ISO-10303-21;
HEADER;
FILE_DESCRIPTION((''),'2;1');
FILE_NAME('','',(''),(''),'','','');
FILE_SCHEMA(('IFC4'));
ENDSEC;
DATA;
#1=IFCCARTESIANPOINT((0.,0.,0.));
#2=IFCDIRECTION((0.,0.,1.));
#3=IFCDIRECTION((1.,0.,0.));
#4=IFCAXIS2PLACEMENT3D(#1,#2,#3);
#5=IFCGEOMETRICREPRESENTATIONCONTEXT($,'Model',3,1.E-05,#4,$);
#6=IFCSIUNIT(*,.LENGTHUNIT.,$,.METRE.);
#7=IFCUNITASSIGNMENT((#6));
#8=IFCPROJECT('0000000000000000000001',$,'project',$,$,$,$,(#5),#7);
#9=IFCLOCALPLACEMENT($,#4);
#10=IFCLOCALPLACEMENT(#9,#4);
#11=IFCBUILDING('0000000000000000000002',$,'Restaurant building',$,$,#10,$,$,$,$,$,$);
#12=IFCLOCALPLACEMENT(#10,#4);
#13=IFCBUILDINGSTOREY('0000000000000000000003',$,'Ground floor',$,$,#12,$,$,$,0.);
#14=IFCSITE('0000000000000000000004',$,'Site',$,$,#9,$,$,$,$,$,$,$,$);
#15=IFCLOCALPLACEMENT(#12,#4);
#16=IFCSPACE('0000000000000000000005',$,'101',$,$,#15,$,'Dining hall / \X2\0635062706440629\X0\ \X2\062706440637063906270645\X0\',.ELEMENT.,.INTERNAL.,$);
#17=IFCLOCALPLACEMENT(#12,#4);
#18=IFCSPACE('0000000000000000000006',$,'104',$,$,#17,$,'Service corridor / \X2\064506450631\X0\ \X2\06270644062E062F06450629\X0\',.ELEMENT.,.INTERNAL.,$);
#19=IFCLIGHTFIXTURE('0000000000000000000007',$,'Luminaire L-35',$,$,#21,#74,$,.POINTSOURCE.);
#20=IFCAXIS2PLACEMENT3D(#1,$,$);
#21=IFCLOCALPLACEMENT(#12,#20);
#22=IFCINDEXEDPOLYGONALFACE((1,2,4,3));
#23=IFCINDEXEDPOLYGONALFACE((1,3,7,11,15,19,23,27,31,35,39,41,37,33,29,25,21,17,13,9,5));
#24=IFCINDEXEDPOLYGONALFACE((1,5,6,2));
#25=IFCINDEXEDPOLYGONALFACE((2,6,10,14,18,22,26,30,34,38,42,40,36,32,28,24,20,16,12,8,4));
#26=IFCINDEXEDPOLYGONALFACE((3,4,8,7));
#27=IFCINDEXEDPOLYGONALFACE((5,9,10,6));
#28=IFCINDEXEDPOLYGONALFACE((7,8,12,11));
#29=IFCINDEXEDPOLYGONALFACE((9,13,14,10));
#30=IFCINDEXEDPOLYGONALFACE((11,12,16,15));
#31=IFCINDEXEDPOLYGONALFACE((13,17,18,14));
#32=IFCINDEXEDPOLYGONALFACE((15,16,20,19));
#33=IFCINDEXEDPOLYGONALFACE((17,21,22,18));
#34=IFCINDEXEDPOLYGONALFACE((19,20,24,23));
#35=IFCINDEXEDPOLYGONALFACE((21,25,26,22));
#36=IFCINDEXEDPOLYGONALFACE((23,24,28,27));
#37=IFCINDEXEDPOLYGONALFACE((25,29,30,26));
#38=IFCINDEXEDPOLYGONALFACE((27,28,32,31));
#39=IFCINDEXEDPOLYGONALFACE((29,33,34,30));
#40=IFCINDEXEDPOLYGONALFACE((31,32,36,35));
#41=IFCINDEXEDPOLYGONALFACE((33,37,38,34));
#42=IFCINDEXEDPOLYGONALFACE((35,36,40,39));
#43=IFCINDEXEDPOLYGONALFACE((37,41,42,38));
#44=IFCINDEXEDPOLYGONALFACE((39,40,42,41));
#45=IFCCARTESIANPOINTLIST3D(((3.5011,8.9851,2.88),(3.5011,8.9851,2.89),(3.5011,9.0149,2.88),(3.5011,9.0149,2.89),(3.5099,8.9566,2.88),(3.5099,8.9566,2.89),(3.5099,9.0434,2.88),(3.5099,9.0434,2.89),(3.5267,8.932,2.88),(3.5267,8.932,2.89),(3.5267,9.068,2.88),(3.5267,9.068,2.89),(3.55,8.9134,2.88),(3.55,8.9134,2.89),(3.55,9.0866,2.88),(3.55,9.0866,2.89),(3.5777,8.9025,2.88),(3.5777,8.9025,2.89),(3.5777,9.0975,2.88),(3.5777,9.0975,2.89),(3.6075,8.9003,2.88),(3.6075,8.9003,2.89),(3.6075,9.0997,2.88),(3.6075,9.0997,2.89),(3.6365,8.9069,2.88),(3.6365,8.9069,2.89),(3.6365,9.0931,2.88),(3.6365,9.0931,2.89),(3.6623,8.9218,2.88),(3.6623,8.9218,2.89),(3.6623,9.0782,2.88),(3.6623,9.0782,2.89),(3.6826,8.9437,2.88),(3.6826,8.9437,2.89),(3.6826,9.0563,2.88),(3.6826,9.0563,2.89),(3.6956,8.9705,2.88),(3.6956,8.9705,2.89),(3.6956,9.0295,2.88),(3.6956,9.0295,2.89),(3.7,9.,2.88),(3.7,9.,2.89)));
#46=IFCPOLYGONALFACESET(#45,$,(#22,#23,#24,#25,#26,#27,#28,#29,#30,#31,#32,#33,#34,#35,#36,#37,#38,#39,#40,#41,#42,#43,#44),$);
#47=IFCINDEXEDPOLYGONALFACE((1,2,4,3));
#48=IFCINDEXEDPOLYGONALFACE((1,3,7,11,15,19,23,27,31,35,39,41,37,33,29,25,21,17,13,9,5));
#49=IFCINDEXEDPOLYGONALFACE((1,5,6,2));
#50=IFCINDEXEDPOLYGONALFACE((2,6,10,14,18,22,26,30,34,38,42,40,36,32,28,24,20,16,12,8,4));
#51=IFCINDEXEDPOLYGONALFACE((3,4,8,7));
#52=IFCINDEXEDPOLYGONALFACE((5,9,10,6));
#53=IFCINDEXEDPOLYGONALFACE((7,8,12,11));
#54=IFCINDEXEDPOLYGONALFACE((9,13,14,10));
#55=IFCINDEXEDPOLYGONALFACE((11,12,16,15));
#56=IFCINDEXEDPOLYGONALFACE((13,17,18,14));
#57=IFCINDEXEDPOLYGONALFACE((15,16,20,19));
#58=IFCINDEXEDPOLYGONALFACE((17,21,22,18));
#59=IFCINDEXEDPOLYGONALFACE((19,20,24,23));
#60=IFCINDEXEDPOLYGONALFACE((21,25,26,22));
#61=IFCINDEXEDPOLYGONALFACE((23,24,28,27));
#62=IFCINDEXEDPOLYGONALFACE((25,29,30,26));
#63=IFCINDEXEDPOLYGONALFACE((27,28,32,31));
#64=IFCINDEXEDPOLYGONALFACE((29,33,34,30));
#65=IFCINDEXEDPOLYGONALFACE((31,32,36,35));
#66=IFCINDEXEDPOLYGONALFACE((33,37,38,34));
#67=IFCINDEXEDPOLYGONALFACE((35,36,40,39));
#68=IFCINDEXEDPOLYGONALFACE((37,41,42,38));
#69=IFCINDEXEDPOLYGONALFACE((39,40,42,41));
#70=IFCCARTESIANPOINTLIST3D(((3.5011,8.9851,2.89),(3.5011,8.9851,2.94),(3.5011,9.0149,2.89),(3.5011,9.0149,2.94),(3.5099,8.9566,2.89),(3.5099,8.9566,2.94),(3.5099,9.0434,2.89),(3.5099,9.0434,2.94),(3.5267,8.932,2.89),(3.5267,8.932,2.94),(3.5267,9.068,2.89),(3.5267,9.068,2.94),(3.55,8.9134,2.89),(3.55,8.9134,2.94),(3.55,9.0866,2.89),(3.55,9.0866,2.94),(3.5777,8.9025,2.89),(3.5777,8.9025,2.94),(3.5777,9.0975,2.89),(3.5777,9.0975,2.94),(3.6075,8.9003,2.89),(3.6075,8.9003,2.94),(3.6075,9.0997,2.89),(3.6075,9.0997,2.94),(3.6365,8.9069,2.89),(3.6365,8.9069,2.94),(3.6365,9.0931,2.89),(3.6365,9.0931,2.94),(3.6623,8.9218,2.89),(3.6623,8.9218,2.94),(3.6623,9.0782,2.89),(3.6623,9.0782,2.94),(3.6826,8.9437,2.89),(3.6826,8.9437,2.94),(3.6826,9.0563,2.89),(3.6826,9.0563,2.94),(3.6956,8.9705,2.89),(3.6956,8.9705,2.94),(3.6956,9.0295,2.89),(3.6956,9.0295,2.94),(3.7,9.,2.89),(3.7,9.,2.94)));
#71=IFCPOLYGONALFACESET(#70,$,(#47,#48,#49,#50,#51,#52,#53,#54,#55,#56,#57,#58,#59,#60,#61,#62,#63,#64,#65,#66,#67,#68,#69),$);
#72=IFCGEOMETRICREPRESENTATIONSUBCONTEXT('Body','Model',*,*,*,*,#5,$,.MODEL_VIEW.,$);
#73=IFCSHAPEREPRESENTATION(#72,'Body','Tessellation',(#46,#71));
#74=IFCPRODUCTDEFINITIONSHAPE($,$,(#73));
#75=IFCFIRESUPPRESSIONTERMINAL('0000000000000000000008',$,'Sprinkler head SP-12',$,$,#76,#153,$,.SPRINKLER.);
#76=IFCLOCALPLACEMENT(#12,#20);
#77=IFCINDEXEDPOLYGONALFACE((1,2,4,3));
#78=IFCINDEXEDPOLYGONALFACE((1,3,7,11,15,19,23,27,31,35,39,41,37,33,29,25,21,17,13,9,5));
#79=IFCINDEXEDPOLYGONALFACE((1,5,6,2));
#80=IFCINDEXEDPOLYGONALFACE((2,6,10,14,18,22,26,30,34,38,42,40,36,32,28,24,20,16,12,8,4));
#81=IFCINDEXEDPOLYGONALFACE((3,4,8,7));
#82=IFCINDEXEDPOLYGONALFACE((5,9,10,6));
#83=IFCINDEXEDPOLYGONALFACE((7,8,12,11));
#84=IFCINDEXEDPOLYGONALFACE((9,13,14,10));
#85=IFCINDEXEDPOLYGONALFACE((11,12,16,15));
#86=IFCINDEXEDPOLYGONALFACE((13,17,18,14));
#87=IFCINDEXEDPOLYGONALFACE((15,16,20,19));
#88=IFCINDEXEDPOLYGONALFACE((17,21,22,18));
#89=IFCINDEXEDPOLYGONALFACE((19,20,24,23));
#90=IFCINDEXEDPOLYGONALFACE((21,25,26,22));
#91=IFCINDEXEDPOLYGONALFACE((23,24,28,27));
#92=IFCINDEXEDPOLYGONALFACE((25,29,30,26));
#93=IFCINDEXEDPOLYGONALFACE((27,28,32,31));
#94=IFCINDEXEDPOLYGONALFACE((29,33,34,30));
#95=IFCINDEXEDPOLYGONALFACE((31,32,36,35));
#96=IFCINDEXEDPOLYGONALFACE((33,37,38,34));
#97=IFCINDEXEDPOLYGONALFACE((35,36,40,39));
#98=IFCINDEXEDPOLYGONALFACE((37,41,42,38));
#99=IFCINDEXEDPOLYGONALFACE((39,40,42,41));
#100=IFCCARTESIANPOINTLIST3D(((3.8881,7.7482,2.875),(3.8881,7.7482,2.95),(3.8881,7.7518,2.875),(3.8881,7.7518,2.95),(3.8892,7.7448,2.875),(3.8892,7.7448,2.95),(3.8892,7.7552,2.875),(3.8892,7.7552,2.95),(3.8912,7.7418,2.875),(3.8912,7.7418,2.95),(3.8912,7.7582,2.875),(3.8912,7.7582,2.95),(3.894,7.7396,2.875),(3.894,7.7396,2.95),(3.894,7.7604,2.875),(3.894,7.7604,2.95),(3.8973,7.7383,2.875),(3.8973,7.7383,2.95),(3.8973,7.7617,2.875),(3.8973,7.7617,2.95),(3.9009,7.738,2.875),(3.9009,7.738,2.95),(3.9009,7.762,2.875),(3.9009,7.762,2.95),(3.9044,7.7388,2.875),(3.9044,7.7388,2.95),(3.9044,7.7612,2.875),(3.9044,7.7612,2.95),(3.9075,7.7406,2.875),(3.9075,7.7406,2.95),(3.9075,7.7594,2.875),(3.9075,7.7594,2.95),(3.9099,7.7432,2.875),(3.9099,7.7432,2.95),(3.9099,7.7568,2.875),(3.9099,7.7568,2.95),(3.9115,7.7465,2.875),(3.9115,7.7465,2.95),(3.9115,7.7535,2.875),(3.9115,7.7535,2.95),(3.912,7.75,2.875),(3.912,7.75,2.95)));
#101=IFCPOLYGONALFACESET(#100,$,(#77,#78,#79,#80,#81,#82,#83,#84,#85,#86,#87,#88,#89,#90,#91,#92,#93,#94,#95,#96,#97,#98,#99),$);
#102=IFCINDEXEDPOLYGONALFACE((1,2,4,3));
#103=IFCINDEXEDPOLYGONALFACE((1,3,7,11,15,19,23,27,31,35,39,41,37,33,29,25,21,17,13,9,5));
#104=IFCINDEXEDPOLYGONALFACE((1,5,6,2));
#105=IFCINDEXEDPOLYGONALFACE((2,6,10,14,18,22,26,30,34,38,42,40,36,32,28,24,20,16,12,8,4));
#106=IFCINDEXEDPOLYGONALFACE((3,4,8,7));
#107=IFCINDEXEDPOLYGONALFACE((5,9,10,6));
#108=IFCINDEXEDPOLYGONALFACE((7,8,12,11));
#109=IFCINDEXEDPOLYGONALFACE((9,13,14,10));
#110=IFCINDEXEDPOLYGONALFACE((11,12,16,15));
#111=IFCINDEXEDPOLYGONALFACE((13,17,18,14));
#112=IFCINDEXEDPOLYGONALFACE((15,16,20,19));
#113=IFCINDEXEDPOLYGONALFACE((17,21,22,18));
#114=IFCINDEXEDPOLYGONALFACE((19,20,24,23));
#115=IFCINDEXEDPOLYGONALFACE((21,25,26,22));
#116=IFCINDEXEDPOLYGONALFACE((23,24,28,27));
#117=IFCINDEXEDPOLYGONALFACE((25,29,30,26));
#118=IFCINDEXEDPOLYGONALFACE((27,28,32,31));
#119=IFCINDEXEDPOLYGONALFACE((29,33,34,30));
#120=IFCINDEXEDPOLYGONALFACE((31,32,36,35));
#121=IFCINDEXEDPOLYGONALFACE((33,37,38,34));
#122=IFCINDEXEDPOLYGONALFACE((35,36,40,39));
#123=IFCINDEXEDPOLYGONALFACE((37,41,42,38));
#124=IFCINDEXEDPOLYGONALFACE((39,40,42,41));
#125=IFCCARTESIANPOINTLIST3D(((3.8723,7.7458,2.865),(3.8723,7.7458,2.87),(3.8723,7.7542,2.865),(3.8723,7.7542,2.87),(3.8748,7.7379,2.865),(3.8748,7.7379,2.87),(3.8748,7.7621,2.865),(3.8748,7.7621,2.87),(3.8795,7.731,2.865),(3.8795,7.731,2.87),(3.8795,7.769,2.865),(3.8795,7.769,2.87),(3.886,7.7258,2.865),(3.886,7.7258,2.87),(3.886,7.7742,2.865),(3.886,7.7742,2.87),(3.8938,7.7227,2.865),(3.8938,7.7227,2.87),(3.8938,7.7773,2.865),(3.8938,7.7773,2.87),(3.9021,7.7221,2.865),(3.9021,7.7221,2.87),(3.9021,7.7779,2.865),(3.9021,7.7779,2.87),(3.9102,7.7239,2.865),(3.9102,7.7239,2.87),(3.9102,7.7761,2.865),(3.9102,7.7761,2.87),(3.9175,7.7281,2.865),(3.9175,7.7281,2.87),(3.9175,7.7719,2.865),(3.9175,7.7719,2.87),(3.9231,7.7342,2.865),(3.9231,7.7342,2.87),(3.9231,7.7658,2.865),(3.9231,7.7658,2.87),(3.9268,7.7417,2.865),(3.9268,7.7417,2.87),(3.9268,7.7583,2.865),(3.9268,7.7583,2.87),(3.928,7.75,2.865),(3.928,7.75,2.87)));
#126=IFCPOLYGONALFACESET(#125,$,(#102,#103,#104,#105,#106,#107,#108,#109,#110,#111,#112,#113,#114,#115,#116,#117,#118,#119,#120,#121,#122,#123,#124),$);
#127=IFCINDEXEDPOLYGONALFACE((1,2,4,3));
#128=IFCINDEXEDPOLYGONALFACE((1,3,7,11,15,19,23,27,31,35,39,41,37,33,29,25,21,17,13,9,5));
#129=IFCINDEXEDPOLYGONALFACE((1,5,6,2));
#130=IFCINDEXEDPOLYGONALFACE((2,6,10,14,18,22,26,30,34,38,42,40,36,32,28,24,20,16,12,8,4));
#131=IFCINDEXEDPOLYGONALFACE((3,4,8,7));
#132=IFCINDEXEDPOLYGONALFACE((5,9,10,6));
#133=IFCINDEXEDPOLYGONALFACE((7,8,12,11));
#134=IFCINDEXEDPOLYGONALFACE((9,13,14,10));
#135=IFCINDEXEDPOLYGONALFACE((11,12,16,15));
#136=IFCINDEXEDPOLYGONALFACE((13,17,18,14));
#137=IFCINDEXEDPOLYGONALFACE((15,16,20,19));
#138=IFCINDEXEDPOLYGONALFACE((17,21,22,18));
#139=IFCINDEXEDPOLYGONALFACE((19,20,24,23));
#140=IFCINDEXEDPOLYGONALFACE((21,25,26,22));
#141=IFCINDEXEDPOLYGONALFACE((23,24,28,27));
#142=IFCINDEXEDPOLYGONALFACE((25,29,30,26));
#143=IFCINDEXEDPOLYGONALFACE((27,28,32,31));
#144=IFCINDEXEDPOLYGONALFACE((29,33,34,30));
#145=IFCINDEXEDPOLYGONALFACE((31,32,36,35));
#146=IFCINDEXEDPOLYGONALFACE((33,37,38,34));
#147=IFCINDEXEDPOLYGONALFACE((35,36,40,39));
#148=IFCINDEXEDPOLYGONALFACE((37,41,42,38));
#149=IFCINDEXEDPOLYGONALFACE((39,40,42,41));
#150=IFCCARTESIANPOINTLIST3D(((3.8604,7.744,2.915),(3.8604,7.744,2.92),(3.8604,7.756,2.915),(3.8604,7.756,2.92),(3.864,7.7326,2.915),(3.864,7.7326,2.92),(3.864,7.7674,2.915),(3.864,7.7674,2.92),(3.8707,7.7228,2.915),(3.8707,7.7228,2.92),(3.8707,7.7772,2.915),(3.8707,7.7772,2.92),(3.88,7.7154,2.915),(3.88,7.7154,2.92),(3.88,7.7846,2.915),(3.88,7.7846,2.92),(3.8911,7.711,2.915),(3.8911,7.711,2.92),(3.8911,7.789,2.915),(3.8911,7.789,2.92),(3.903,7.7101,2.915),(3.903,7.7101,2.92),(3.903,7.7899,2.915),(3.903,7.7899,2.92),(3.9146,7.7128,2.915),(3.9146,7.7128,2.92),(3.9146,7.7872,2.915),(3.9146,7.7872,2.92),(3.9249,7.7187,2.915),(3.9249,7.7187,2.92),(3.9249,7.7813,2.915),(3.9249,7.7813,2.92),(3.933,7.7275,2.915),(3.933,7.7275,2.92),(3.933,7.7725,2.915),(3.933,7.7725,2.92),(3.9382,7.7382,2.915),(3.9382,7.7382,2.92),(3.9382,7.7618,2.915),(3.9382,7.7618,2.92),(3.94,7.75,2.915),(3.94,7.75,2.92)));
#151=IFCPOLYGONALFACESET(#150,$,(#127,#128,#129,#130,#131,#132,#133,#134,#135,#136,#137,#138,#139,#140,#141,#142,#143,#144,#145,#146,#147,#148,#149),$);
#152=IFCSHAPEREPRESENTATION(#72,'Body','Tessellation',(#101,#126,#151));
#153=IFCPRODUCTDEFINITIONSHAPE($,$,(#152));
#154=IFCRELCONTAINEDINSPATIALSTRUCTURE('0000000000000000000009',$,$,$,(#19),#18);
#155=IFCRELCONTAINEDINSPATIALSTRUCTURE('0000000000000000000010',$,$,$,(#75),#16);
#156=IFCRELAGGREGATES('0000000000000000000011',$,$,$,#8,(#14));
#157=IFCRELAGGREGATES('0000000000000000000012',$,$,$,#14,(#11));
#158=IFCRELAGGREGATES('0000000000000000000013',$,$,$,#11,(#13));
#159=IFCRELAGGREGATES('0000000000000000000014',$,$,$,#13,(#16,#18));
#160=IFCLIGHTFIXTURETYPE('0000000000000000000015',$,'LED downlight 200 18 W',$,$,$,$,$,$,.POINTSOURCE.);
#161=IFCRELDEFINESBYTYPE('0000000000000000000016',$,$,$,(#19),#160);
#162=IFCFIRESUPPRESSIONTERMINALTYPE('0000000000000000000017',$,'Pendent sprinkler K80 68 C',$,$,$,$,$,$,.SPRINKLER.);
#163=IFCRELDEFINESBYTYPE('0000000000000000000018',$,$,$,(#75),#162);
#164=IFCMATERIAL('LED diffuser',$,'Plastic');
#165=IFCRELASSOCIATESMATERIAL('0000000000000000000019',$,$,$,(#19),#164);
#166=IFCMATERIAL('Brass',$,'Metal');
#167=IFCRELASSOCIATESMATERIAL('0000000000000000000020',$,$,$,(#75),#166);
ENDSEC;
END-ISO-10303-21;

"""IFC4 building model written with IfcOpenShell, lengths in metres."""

from ifc_helpers import new_model, si_unit, frame, origin, origin_with_axes, origin_2d, place, context, subcontext, project, spatial, circle, extrude, source, transform, mapped, material, type_object, type_shapes, element, save


model = new_model("IFC4")

# Units and contexts
model_context = context("Model", 3, precision=1e-05, world=origin_with_axes())
body_context = subcontext(model_context, "Body", "Model", "MODEL_VIEW")
ifc_project = project(units=[si_unit("LENGTHUNIT", "METRE")], contexts=[model_context])

# Site, building, storey
site_placement = place(None, origin_with_axes())
site = spatial("IfcSite", under=ifc_project, at=site_placement, Name="Site")
building_placement = place(site_placement, origin_with_axes())
building = spatial("IfcBuilding", under=site, at=building_placement, Name="Restaurant building")
storey_placement = place(building_placement, origin_with_axes())
storey = spatial("IfcBuildingStorey", under=building, at=storey_placement, Name="Ground floor", Elevation=0.0)

# Shared definitions
space_1_placement = place(storey_placement, origin_with_axes())
space_1 = spatial("IfcSpace", under=storey, at=space_1_placement, Name="101", LongName="Dining hall / صالة الطعام", CompositionType="ELEMENT", PredefinedType="INTERNAL")

# Shared definitions
ifc_material_1 = material(Name="LED diffuser", Category="Plastic")

# Shared definitions
space_2_placement = place(storey_placement, origin_with_axes())
space_2 = spatial("IfcSpace", under=storey, at=space_2_placement, Name="104", LongName="Service corridor / ممر الخدمة", CompositionType="ELEMENT", PredefinedType="INTERNAL")

# Light fixture
light_fixture_type_1 = type_object("IfcLightFixtureType", Name="LED downlight 200 18 W", PredefinedType="POINTSOURCE")
shared_shape_1 = source(origin(), body_context, "Body", "SweptSolid", [
    extrude(circle(Radius=0.1, at=origin_2d()), frame((0.0, 0.0, -0.06)), (0.0, 0.0, 1.0), 0.01),
    extrude(circle(Radius=0.1, at=origin_2d()), frame((0.0, 0.0, -0.05)), (0.0, 0.0, 1.0), 0.05),
])
type_shapes(light_fixture_type_1, [shared_shape_1])
light_fixture_1_placement = place(storey_placement, frame((3.6, 9.0, 2.94)))
element("IfcLightFixture", 1, at=light_fixture_1_placement, inside=space_2, type_object=light_fixture_type_1, material=ifc_material_1, Name="Luminaire L-35", PredefinedType="POINTSOURCE", context=body_context, shape_type="MappedRepresentation", body=[
    mapped(shared_shape_1, transform((0.0, 0.0, 0.0))),
])

# Fire suppression terminal
ifc_material_2 = material(Name="Brass", Category="Metal")
fire_suppression_terminal_type = type_object("IfcFireSuppressionTerminalType", Name="Pendent sprinkler K80 68 C", PredefinedType="SPRINKLER")
shared_shape_2 = source(origin(), body_context, "Body", "SweptSolid", [
    extrude(circle(Radius=0.012, at=origin_2d()), frame((0.0, 0.0, -0.075)), (0.0, 0.0, 1.0), 0.075),
    extrude(circle(Radius=0.028, at=origin_2d()), frame((0.0, 0.0, -0.085)), (0.0, 0.0, 1.0), 0.005),
    extrude(circle(Radius=0.04, at=origin_2d()), frame((0.0, 0.0, -0.035)), (0.0, 0.0, 1.0), 0.005),
])
type_shapes(fire_suppression_terminal_type, [shared_shape_2])
for number, where, name in (
    (2, (3.9, 7.75, 2.95), "Sprinkler head SP-12"),
):
    element("IfcFireSuppressionTerminal", number, at=place(storey_placement, frame(where)), inside=space_1, type_object=fire_suppression_terminal_type, material=ifc_material_2, Name=name, PredefinedType="SPRINKLER", context=body_context, shape_type="MappedRepresentation", body=[
        mapped(shared_shape_2, transform((0.0, 0.0, 0.0))),
    ])

save(model, "model.ifc")
